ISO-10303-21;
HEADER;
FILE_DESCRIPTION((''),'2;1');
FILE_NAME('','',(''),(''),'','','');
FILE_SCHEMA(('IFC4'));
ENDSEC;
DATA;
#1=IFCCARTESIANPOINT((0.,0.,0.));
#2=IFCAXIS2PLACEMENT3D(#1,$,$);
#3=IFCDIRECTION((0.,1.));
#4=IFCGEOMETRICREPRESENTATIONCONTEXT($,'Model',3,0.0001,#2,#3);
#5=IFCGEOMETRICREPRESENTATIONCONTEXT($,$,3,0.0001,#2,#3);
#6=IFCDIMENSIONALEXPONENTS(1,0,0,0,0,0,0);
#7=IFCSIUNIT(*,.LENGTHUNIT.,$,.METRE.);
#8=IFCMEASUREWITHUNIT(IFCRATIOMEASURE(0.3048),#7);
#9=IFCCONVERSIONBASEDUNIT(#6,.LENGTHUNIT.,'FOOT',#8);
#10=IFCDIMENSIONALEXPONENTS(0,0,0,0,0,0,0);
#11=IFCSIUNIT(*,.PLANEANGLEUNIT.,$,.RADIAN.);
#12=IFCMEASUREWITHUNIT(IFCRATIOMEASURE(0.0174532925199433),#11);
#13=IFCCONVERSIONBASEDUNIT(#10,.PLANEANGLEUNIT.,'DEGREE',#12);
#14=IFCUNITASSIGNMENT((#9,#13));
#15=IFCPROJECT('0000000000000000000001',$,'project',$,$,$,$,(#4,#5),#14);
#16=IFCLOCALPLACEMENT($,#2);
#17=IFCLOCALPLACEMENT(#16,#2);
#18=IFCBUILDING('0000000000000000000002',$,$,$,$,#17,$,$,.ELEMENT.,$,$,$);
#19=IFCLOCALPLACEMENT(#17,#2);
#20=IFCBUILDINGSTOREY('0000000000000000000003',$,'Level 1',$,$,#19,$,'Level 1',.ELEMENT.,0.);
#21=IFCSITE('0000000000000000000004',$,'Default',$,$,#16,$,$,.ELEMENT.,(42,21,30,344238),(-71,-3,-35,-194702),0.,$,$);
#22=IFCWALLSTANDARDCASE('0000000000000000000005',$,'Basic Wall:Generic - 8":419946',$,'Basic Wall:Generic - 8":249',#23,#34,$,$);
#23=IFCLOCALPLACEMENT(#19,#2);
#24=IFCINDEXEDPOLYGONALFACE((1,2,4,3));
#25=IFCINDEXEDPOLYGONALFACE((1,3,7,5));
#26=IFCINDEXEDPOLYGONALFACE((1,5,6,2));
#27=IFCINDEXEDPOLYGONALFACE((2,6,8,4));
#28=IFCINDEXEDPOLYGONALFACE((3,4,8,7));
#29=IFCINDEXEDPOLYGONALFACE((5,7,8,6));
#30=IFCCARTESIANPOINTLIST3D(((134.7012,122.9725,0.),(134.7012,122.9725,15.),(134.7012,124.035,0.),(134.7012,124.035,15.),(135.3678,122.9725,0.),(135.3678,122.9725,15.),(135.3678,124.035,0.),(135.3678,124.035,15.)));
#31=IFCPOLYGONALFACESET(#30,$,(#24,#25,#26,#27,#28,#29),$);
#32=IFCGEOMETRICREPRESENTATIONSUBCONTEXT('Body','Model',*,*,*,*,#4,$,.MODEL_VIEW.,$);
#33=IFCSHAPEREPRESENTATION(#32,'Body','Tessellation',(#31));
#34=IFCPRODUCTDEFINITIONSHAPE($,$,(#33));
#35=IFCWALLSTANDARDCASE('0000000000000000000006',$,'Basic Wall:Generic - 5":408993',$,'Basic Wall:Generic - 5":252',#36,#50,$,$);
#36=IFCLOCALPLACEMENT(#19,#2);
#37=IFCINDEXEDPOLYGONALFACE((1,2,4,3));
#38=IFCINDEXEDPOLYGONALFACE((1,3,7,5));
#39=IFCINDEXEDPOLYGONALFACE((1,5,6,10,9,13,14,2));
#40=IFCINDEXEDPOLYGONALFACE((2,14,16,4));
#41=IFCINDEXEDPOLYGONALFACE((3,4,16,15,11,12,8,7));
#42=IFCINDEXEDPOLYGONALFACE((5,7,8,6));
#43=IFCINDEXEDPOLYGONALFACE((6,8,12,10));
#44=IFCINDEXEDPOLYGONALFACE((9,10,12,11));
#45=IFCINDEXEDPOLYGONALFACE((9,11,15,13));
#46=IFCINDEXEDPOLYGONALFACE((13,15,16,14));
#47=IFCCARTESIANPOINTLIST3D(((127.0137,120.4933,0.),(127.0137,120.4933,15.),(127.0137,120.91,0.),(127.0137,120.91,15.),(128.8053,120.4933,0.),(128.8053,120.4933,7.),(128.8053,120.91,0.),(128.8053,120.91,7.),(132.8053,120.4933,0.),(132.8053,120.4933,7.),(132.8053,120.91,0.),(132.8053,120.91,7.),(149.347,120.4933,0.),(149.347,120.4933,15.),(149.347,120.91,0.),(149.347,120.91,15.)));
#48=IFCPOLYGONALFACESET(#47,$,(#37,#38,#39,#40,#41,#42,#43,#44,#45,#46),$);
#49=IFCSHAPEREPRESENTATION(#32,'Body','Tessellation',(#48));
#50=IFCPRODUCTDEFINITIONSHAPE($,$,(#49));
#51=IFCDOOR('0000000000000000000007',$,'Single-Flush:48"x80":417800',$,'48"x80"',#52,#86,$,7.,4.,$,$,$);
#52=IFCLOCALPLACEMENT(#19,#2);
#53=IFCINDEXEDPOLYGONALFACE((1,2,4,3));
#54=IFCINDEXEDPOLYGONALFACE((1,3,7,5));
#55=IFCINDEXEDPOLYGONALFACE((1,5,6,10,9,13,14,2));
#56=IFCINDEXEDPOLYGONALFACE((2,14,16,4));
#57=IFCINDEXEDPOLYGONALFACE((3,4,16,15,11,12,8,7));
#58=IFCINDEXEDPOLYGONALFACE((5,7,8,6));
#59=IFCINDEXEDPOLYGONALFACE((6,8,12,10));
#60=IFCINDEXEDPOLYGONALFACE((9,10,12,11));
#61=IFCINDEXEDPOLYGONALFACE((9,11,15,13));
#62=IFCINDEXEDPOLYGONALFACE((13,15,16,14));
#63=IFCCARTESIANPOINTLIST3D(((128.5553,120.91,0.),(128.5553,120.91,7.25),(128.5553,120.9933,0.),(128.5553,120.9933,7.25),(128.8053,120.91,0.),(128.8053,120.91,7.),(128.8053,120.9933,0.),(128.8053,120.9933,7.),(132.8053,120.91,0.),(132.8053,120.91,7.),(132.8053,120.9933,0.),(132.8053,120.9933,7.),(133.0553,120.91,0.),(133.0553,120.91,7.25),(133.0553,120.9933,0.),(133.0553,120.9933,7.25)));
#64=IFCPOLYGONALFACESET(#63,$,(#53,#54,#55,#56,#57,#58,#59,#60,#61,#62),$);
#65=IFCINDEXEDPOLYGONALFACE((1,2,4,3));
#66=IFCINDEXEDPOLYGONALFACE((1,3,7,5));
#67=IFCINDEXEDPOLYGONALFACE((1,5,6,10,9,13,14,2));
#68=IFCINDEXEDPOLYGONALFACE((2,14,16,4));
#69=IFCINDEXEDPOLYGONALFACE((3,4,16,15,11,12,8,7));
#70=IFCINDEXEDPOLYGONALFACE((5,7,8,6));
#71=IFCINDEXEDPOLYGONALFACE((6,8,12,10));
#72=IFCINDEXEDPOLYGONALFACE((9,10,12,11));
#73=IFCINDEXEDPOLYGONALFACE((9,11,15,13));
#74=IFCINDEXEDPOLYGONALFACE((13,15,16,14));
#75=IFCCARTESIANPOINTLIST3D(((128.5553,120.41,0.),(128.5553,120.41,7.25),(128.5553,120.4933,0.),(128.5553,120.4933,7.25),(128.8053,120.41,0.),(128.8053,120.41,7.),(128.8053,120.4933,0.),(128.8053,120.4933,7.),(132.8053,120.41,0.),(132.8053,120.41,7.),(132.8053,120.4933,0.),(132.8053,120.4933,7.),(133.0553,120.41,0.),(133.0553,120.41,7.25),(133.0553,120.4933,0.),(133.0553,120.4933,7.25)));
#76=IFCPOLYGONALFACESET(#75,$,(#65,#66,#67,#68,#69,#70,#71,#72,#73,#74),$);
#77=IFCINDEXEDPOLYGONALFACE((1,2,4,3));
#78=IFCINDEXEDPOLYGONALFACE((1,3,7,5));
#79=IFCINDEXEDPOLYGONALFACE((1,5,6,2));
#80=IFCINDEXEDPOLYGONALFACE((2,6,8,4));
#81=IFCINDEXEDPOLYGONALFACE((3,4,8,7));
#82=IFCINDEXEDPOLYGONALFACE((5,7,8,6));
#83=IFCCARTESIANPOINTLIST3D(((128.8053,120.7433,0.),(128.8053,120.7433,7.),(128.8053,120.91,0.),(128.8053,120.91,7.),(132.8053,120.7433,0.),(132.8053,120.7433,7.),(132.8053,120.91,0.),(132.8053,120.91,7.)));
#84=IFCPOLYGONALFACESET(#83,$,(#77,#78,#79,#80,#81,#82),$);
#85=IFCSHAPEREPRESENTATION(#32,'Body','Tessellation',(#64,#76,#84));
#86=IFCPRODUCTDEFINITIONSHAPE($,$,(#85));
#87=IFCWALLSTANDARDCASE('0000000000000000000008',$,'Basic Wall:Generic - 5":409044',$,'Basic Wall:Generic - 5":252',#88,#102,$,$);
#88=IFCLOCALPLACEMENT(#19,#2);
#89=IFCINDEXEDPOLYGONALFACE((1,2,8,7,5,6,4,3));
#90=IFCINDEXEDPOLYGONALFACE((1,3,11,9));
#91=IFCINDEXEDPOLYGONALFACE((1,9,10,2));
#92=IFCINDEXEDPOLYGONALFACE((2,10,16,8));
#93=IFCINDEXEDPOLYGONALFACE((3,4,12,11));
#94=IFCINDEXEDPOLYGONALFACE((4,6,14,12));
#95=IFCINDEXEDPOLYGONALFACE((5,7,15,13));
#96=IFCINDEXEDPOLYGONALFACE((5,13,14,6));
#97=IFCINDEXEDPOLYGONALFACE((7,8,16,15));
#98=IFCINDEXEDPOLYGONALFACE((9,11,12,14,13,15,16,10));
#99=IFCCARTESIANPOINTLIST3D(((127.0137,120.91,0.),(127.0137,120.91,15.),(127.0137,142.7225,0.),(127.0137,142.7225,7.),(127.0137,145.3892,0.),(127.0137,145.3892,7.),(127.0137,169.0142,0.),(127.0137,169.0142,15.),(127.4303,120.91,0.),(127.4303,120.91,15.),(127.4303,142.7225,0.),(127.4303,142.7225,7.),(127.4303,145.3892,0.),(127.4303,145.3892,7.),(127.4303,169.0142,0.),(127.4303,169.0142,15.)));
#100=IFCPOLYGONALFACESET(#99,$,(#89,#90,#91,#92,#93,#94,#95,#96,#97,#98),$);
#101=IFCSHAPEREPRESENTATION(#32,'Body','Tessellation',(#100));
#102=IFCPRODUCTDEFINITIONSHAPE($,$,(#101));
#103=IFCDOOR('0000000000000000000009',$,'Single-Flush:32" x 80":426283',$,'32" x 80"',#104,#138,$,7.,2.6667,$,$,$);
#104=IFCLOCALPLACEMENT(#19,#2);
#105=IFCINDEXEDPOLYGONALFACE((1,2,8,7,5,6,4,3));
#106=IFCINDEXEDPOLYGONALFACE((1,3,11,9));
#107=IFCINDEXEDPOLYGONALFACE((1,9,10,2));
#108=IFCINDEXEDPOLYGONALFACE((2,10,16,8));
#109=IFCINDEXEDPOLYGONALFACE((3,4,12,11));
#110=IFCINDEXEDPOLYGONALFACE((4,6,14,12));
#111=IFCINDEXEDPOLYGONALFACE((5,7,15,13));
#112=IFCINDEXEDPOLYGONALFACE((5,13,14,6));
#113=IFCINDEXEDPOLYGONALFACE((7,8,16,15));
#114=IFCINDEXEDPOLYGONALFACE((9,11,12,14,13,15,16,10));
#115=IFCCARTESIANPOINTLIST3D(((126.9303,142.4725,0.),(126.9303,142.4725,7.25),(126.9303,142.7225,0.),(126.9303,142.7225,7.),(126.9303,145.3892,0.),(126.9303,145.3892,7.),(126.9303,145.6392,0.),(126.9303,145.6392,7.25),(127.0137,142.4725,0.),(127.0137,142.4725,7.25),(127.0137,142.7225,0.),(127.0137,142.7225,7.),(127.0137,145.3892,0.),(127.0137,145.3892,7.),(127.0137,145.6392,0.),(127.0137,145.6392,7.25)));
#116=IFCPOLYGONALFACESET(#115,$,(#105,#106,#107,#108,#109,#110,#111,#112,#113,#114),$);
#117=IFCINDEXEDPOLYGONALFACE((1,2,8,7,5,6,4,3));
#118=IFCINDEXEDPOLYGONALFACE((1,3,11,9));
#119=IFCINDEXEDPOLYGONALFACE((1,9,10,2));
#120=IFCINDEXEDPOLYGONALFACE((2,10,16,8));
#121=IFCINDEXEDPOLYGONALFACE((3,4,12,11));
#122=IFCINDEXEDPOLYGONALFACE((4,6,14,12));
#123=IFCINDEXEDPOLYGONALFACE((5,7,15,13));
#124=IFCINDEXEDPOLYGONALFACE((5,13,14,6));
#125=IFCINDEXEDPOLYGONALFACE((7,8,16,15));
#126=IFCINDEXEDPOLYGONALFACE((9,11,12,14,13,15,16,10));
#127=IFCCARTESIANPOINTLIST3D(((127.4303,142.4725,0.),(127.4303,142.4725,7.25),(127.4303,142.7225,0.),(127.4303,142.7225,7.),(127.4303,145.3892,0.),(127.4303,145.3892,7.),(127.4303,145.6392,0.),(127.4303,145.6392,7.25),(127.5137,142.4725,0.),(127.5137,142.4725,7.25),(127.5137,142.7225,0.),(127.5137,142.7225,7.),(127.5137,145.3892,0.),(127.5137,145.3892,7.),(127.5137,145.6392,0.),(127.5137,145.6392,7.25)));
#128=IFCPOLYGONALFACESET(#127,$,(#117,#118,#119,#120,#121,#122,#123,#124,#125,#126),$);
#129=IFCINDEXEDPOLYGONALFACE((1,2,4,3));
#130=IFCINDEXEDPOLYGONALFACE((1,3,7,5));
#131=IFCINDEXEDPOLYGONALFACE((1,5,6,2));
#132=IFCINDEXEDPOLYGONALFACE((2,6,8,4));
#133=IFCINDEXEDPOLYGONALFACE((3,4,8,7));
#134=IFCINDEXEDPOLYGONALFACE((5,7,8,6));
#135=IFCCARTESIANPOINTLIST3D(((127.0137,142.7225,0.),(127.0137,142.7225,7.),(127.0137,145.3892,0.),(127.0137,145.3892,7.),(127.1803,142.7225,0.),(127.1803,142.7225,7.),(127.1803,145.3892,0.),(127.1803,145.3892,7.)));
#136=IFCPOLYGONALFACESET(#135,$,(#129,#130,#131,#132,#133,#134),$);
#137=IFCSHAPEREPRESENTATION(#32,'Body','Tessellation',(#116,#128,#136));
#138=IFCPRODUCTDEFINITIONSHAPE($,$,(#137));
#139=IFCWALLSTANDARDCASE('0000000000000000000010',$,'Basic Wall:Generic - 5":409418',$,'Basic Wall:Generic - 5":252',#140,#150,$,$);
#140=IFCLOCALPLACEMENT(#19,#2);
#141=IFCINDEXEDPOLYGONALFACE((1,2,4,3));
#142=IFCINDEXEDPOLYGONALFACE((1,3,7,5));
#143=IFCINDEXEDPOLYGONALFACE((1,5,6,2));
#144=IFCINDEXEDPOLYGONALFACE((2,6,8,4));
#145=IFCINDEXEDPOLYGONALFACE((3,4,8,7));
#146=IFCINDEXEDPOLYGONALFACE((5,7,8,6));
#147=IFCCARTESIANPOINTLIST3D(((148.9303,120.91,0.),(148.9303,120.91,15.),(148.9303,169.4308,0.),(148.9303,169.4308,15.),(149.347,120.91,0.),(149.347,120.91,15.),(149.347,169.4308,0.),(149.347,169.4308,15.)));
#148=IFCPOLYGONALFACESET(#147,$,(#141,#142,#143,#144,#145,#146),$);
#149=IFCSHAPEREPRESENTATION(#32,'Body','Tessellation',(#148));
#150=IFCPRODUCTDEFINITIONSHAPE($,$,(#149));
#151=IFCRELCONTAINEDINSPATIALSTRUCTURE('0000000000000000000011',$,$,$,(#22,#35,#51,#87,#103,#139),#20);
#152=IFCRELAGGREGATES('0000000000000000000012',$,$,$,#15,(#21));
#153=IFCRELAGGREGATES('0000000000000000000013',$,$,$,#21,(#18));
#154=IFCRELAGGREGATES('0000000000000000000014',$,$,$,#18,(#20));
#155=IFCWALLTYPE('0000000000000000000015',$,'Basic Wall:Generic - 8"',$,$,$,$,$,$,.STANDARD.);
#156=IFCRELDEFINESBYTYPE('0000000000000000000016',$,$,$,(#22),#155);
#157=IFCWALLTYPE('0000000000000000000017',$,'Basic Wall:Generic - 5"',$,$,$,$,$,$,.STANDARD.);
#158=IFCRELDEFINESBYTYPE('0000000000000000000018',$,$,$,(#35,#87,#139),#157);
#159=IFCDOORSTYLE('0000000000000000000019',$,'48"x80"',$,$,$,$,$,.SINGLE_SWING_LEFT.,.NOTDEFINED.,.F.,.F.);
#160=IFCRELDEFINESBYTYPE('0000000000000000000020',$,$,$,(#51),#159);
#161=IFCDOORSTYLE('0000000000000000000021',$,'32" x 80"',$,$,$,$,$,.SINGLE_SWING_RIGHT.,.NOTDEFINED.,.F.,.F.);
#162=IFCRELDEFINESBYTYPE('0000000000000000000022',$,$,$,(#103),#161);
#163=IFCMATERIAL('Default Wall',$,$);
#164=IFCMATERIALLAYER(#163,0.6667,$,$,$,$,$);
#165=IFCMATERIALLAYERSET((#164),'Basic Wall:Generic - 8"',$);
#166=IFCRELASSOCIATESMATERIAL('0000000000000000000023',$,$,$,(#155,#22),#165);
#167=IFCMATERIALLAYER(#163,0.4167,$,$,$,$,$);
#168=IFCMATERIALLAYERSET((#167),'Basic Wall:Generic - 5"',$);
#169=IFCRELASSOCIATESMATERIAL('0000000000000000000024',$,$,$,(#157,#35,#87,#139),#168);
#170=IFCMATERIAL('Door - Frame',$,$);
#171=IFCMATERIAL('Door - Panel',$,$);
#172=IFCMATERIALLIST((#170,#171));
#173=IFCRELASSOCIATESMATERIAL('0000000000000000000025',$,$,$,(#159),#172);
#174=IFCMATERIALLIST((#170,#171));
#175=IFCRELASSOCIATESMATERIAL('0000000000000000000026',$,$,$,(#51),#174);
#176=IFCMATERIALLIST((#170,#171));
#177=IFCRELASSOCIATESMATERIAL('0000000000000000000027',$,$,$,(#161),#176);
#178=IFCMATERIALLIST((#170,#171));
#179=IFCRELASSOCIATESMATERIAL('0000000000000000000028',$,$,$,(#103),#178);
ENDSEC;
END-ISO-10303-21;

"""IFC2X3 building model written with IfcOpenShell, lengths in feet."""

from ifc_helpers import new_model, entity, si_unit, converted_unit, direction, frame, frame_2d, origin, origin_2d_with_axis, place, context, subcontext, project, spatial, polyline, rectangle, outline, extrude, source, transform, mapped, material, material_list, layer, layer_set, layer_usage, type_object, type_shapes, element, fill, save


model = new_model("IFC2X3")

# Units and contexts
model_context = context("Model", 3, precision=0.0001, world=origin(), true_north=direction((0.0, 1.0)))
context_of_model = context(None, 3, precision=0.0001, world=origin(), true_north=direction((0.0, 1.0)))
body_context = subcontext(model_context, "Body", "Model", "MODEL_VIEW")
ifc_project = project(units=[converted_unit("LENGTHUNIT", "FOOT", entity("IfcRatioMeasure", 0.3048), si_unit("LENGTHUNIT", "METRE"), dimensions=[1, 0, 0, 0, 0, 0, 0]), converted_unit("PLANEANGLEUNIT", "DEGREE", entity("IfcRatioMeasure", 0.0174532925199433), si_unit("PLANEANGLEUNIT", "RADIAN"), dimensions=[0, 0, 0, 0, 0, 0, 0])], contexts=[model_context, context_of_model])

# Site, building, storey
site_placement = place(None, origin())
site = spatial("IfcSite", under=ifc_project, at=site_placement, Name="Default", CompositionType="ELEMENT", RefLatitude=(42, 21, 30, 344238), RefLongitude=(-71, -3, -35, -194702), RefElevation=0.0)
building_placement = place(site_placement, origin())
building = spatial("IfcBuilding", under=site, at=building_placement, CompositionType="ELEMENT")
storey_placement = place(building_placement, origin())
storey = spatial("IfcBuildingStorey", under=building, at=storey_placement, Name="Level 1", LongName="Level 1", CompositionType="ELEMENT", Elevation=0.0)

# Wall
ifc_material_1 = material(Name="Default Wall")
ifc_layer_1 = layer(ifc_material_1, 0.6667)
ifc_layer_set_1 = layer_set([ifc_layer_1], Name="Basic Wall:Generic - 8\"")
ifc_layer_usage_1 = layer_usage(ifc_layer_set_1, "AXIS2", "NEGATIVE", 0.3333)
wall_type_1 = type_object("IfcWallType", Name="Basic Wall:Generic - 8\"", PredefinedType="STANDARD", material=ifc_layer_set_1)
wall_1_placement = place(storey_placement, frame((135.0345, 122.9725, 0.0), z_axis=(0.0, 0.0, 1.0), x_axis=(0.0, 1.0, 0.0)))
element("IfcWallStandardCase", 1, at=wall_1_placement, inside=storey, type_object=wall_type_1, material=ifc_layer_usage_1, Name="Basic Wall:Generic - 8\":419946", ObjectType="Basic Wall:Generic - 8\":249", context=body_context, shape_type="SweptSolid", body=[
    extrude(rectangle(XDim=1.0625, YDim=0.6667, at=frame_2d((0.5312, 0.0), x_axis=(-1.0, 0.0))), origin(), (0.0, 0.0, 1.0), 15.0),
])

# Walls, openings, doors
ifc_layer_2 = layer(ifc_material_1, 0.4167)
ifc_layer_set_2 = layer_set([ifc_layer_2], Name="Basic Wall:Generic - 5\"")
ifc_layer_usage_2 = layer_usage(ifc_layer_set_2, "AXIS2", "NEGATIVE", 0.2083)
wall_type_2 = type_object("IfcWallType", Name="Basic Wall:Generic - 5\"", PredefinedType="STANDARD", material=ifc_layer_set_2)
wall_2_placement = place(storey_placement, frame((149.347, 120.7017, 0.0), z_axis=(0.0, 0.0, 1.0), x_axis=(-1.0, 0.0, 0.0)))
wall_2 = element("IfcWallStandardCase", 2, at=wall_2_placement, inside=storey, type_object=wall_type_2, material=ifc_layer_usage_2, Name="Basic Wall:Generic - 5\":408993", ObjectType="Basic Wall:Generic - 5\":252", context=body_context, shape_type="SweptSolid", body=[
    extrude(rectangle(XDim=22.3333, YDim=0.4167, at=frame_2d((11.1667, 0.0), x_axis=(-1.0, 0.0))), origin(), (0.0, 0.0, 1.0), 15.0),
])
opening_1_placement = place(wall_2_placement, frame((20.5417, 0.2083, 0.0)))
opening_1 = element("IfcOpeningElement", 3, at=opening_1_placement, cuts=wall_2, ObjectType="Opening", context=body_context, shape_type="SweptSolid", body=[
    extrude(rectangle(XDim=4.0, YDim=7.0, at=frame_2d((3.5, 2.0), x_axis=(0.0, -1.0))), frame((0.0, 0.0, 0.0), z_axis=(0.0, -1.0, 0.0), x_axis=(0.0, 0.0, 1.0)), (0.0, 0.0, 1.0), 0.4167),
])
ifc_material_2 = material(Name="Door - Frame")
ifc_material_3 = material(Name="Door - Panel")
ifc_material_list_1 = material_list([ifc_material_2, ifc_material_3])
ifc_material_list_2 = material_list([ifc_material_2, ifc_material_3])
door_style_1 = type_object("IfcDoorStyle", Name="48\"x80\"", ConstructionType="NOTDEFINED", OperationType="SINGLE_SWING_LEFT", ParameterTakesPrecedence=False, Sizeable=False, material=ifc_material_list_2)
shared_shape_1 = source(origin(), body_context, "Body", "SweptSolid", [
    extrude(outline(polyline([(-2.25, -3.6875), (2.25, -3.6875), (2.25, 3.5625), (2.0, 3.5625), (2.0, -3.4375), (-2.0, -3.4375), (-2.0, 3.5625), (-2.25, 3.5625), (-2.25, -3.6875)])), frame((2.0, 0.5, 3.5625), z_axis=(0.0, -1.0, 0.0), x_axis=(-1.0, 0.0, 0.0)), (0.0, 0.0, 1.0), 0.0833),
    extrude(outline(polyline([(-3.6875, -2.25), (3.5625, -2.25), (3.5625, -2.0), (-3.4375, -2.0), (-3.4375, 2.0), (3.5625, 2.0), (3.5625, 2.25), (-3.6875, 2.25), (-3.6875, -2.25)])), frame((2.0, 0.0, 3.5625), z_axis=(0.0, -1.0, 0.0), x_axis=(0.0, 0.0, -1.0)), (0.0, 0.0, 1.0), 0.0833),
    extrude(rectangle(XDim=4.0, YDim=0.1667, at=origin_2d_with_axis()), frame((2.0, 0.3333, 0.0)), (0.0, 0.0, 1.0), 7.0),
])
type_shapes(door_style_1, [shared_shape_1])
door_1_placement = place(opening_1_placement, frame((0.0, 0.0, 0.0), z_axis=(0.0, 0.0, 1.0), x_axis=(-1.0, 0.0, 0.0)))
door_1 = element("IfcDoor", 4, at=door_1_placement, inside=storey, type_object=door_style_1, material=ifc_material_list_1, Name="Single-Flush:48\"x80\":417800", ObjectType="48\"x80\"", OverallHeight=7.0, OverallWidth=4.0, context=body_context, shape_type="MappedRepresentation", body=[
    mapped(shared_shape_1, transform((0.0, 0.0, 0.0), scale=1.0)),
])
fill(opening_1, door_1)
ifc_layer_usage_3 = layer_usage(ifc_layer_set_2, "AXIS2", "NEGATIVE", 0.2083)
wall_3_placement = place(storey_placement, frame((127.222, 120.91, 0.0), z_axis=(0.0, 0.0, 1.0), x_axis=(0.0, 1.0, 0.0)))
wall_3 = element("IfcWallStandardCase", 5, at=wall_3_placement, inside=storey, type_object=wall_type_2, material=ifc_layer_usage_3, Name="Basic Wall:Generic - 5\":409044", ObjectType="Basic Wall:Generic - 5\":252", context=body_context, shape_type="SweptSolid", body=[
    extrude(rectangle(XDim=48.1042, YDim=0.4167, at=frame_2d((24.0521, 0.0), x_axis=(-1.0, 0.0))), origin(), (0.0, 0.0, 1.0), 15.0),
])
opening_2_placement = place(wall_3_placement, frame((21.8125, -0.2083, 0.0)))
opening_2 = element("IfcOpeningElement", 6, at=opening_2_placement, cuts=wall_3, ObjectType="Opening", context=body_context, shape_type="SweptSolid", body=[
    extrude(rectangle(XDim=2.6667, YDim=7.0, at=frame_2d((3.5, 1.3333), x_axis=(0.0, 1.0))), frame((0.0, 0.0, 0.0), z_axis=(0.0, 1.0, 0.0), x_axis=(0.0, 0.0, 1.0)), (0.0, 0.0, 1.0), 0.4167),
])
ifc_material_list_3 = material_list([ifc_material_2, ifc_material_3])
ifc_material_list_4 = material_list([ifc_material_2, ifc_material_3])
door_style_2 = type_object("IfcDoorStyle", Name="32\" x 80\"", ConstructionType="NOTDEFINED", OperationType="SINGLE_SWING_RIGHT", ParameterTakesPrecedence=False, Sizeable=False, material=ifc_material_list_4)
shared_shape_2 = source(origin(), body_context, "Body", "SweptSolid", [
    extrude(outline(polyline([(-1.5833, -3.6875), (1.5833, -3.6875), (1.5833, 3.5625), (1.3333, 3.5625), (1.3333, -3.4375), (-1.3333, -3.4375), (-1.3333, 3.5625), (-1.5833, 3.5625), (-1.5833, -3.6875)])), frame((1.3333, 0.4167, 3.5625), z_axis=(0.0, 1.0, 0.0), x_axis=(1.0, 0.0, 0.0)), (0.0, 0.0, 1.0), 0.0833),
    extrude(outline(polyline([(-3.6875, -1.5833), (3.5625, -1.5833), (3.5625, -1.3333), (-3.4375, -1.3333), (-3.4375, 1.3333), (3.5625, 1.3333), (3.5625, 1.5833), (-3.6875, 1.5833), (-3.6875, -1.5833)])), frame((1.3333, -0.0833, 3.5625), z_axis=(0.0, 1.0, 0.0), x_axis=(0.0, 0.0, -1.0)), (0.0, 0.0, 1.0), 0.0833),
    extrude(rectangle(XDim=0.1667, YDim=2.6667, at=frame_2d((0.0, 0.0), x_axis=(1.0, 0.0))), frame((1.3333, 0.3333, 0.0), z_axis=(0.0, 0.0, 1.0), x_axis=(0.0, 1.0, 0.0)), (0.0, 0.0, 1.0), 7.0),
])
type_shapes(door_style_2, [shared_shape_2])
door_2_placement = place(opening_2_placement, origin())
door_2 = element("IfcDoor", 7, at=door_2_placement, inside=storey, type_object=door_style_2, material=ifc_material_list_3, Name="Single-Flush:32\" x 80\":426283", ObjectType="32\" x 80\"", OverallHeight=7.0, OverallWidth=2.6667, context=body_context, shape_type="MappedRepresentation", body=[
    mapped(shared_shape_2, transform((0.0, 0.0, 0.0), scale=1.0)),
])
fill(opening_2, door_2)

# Wall
ifc_layer_usage_4 = layer_usage(ifc_layer_set_2, "AXIS2", "NEGATIVE", 0.2083)
wall_4_placement = place(storey_placement, frame((149.1387, 120.91, 0.0), z_axis=(0.0, 0.0, 1.0), x_axis=(0.0, 1.0, 0.0)))
element("IfcWallStandardCase", 8, at=wall_4_placement, inside=storey, type_object=wall_type_2, material=ifc_layer_usage_4, Name="Basic Wall:Generic - 5\":409418", ObjectType="Basic Wall:Generic - 5\":252", context=body_context, shape_type="SweptSolid", body=[
    extrude(rectangle(XDim=48.5208, YDim=0.4167, at=frame_2d((24.2604, 0.0), x_axis=(-1.0, 0.0))), origin(), (0.0, 0.0, 1.0), 15.0),
])

save(model, "model.ifc")
